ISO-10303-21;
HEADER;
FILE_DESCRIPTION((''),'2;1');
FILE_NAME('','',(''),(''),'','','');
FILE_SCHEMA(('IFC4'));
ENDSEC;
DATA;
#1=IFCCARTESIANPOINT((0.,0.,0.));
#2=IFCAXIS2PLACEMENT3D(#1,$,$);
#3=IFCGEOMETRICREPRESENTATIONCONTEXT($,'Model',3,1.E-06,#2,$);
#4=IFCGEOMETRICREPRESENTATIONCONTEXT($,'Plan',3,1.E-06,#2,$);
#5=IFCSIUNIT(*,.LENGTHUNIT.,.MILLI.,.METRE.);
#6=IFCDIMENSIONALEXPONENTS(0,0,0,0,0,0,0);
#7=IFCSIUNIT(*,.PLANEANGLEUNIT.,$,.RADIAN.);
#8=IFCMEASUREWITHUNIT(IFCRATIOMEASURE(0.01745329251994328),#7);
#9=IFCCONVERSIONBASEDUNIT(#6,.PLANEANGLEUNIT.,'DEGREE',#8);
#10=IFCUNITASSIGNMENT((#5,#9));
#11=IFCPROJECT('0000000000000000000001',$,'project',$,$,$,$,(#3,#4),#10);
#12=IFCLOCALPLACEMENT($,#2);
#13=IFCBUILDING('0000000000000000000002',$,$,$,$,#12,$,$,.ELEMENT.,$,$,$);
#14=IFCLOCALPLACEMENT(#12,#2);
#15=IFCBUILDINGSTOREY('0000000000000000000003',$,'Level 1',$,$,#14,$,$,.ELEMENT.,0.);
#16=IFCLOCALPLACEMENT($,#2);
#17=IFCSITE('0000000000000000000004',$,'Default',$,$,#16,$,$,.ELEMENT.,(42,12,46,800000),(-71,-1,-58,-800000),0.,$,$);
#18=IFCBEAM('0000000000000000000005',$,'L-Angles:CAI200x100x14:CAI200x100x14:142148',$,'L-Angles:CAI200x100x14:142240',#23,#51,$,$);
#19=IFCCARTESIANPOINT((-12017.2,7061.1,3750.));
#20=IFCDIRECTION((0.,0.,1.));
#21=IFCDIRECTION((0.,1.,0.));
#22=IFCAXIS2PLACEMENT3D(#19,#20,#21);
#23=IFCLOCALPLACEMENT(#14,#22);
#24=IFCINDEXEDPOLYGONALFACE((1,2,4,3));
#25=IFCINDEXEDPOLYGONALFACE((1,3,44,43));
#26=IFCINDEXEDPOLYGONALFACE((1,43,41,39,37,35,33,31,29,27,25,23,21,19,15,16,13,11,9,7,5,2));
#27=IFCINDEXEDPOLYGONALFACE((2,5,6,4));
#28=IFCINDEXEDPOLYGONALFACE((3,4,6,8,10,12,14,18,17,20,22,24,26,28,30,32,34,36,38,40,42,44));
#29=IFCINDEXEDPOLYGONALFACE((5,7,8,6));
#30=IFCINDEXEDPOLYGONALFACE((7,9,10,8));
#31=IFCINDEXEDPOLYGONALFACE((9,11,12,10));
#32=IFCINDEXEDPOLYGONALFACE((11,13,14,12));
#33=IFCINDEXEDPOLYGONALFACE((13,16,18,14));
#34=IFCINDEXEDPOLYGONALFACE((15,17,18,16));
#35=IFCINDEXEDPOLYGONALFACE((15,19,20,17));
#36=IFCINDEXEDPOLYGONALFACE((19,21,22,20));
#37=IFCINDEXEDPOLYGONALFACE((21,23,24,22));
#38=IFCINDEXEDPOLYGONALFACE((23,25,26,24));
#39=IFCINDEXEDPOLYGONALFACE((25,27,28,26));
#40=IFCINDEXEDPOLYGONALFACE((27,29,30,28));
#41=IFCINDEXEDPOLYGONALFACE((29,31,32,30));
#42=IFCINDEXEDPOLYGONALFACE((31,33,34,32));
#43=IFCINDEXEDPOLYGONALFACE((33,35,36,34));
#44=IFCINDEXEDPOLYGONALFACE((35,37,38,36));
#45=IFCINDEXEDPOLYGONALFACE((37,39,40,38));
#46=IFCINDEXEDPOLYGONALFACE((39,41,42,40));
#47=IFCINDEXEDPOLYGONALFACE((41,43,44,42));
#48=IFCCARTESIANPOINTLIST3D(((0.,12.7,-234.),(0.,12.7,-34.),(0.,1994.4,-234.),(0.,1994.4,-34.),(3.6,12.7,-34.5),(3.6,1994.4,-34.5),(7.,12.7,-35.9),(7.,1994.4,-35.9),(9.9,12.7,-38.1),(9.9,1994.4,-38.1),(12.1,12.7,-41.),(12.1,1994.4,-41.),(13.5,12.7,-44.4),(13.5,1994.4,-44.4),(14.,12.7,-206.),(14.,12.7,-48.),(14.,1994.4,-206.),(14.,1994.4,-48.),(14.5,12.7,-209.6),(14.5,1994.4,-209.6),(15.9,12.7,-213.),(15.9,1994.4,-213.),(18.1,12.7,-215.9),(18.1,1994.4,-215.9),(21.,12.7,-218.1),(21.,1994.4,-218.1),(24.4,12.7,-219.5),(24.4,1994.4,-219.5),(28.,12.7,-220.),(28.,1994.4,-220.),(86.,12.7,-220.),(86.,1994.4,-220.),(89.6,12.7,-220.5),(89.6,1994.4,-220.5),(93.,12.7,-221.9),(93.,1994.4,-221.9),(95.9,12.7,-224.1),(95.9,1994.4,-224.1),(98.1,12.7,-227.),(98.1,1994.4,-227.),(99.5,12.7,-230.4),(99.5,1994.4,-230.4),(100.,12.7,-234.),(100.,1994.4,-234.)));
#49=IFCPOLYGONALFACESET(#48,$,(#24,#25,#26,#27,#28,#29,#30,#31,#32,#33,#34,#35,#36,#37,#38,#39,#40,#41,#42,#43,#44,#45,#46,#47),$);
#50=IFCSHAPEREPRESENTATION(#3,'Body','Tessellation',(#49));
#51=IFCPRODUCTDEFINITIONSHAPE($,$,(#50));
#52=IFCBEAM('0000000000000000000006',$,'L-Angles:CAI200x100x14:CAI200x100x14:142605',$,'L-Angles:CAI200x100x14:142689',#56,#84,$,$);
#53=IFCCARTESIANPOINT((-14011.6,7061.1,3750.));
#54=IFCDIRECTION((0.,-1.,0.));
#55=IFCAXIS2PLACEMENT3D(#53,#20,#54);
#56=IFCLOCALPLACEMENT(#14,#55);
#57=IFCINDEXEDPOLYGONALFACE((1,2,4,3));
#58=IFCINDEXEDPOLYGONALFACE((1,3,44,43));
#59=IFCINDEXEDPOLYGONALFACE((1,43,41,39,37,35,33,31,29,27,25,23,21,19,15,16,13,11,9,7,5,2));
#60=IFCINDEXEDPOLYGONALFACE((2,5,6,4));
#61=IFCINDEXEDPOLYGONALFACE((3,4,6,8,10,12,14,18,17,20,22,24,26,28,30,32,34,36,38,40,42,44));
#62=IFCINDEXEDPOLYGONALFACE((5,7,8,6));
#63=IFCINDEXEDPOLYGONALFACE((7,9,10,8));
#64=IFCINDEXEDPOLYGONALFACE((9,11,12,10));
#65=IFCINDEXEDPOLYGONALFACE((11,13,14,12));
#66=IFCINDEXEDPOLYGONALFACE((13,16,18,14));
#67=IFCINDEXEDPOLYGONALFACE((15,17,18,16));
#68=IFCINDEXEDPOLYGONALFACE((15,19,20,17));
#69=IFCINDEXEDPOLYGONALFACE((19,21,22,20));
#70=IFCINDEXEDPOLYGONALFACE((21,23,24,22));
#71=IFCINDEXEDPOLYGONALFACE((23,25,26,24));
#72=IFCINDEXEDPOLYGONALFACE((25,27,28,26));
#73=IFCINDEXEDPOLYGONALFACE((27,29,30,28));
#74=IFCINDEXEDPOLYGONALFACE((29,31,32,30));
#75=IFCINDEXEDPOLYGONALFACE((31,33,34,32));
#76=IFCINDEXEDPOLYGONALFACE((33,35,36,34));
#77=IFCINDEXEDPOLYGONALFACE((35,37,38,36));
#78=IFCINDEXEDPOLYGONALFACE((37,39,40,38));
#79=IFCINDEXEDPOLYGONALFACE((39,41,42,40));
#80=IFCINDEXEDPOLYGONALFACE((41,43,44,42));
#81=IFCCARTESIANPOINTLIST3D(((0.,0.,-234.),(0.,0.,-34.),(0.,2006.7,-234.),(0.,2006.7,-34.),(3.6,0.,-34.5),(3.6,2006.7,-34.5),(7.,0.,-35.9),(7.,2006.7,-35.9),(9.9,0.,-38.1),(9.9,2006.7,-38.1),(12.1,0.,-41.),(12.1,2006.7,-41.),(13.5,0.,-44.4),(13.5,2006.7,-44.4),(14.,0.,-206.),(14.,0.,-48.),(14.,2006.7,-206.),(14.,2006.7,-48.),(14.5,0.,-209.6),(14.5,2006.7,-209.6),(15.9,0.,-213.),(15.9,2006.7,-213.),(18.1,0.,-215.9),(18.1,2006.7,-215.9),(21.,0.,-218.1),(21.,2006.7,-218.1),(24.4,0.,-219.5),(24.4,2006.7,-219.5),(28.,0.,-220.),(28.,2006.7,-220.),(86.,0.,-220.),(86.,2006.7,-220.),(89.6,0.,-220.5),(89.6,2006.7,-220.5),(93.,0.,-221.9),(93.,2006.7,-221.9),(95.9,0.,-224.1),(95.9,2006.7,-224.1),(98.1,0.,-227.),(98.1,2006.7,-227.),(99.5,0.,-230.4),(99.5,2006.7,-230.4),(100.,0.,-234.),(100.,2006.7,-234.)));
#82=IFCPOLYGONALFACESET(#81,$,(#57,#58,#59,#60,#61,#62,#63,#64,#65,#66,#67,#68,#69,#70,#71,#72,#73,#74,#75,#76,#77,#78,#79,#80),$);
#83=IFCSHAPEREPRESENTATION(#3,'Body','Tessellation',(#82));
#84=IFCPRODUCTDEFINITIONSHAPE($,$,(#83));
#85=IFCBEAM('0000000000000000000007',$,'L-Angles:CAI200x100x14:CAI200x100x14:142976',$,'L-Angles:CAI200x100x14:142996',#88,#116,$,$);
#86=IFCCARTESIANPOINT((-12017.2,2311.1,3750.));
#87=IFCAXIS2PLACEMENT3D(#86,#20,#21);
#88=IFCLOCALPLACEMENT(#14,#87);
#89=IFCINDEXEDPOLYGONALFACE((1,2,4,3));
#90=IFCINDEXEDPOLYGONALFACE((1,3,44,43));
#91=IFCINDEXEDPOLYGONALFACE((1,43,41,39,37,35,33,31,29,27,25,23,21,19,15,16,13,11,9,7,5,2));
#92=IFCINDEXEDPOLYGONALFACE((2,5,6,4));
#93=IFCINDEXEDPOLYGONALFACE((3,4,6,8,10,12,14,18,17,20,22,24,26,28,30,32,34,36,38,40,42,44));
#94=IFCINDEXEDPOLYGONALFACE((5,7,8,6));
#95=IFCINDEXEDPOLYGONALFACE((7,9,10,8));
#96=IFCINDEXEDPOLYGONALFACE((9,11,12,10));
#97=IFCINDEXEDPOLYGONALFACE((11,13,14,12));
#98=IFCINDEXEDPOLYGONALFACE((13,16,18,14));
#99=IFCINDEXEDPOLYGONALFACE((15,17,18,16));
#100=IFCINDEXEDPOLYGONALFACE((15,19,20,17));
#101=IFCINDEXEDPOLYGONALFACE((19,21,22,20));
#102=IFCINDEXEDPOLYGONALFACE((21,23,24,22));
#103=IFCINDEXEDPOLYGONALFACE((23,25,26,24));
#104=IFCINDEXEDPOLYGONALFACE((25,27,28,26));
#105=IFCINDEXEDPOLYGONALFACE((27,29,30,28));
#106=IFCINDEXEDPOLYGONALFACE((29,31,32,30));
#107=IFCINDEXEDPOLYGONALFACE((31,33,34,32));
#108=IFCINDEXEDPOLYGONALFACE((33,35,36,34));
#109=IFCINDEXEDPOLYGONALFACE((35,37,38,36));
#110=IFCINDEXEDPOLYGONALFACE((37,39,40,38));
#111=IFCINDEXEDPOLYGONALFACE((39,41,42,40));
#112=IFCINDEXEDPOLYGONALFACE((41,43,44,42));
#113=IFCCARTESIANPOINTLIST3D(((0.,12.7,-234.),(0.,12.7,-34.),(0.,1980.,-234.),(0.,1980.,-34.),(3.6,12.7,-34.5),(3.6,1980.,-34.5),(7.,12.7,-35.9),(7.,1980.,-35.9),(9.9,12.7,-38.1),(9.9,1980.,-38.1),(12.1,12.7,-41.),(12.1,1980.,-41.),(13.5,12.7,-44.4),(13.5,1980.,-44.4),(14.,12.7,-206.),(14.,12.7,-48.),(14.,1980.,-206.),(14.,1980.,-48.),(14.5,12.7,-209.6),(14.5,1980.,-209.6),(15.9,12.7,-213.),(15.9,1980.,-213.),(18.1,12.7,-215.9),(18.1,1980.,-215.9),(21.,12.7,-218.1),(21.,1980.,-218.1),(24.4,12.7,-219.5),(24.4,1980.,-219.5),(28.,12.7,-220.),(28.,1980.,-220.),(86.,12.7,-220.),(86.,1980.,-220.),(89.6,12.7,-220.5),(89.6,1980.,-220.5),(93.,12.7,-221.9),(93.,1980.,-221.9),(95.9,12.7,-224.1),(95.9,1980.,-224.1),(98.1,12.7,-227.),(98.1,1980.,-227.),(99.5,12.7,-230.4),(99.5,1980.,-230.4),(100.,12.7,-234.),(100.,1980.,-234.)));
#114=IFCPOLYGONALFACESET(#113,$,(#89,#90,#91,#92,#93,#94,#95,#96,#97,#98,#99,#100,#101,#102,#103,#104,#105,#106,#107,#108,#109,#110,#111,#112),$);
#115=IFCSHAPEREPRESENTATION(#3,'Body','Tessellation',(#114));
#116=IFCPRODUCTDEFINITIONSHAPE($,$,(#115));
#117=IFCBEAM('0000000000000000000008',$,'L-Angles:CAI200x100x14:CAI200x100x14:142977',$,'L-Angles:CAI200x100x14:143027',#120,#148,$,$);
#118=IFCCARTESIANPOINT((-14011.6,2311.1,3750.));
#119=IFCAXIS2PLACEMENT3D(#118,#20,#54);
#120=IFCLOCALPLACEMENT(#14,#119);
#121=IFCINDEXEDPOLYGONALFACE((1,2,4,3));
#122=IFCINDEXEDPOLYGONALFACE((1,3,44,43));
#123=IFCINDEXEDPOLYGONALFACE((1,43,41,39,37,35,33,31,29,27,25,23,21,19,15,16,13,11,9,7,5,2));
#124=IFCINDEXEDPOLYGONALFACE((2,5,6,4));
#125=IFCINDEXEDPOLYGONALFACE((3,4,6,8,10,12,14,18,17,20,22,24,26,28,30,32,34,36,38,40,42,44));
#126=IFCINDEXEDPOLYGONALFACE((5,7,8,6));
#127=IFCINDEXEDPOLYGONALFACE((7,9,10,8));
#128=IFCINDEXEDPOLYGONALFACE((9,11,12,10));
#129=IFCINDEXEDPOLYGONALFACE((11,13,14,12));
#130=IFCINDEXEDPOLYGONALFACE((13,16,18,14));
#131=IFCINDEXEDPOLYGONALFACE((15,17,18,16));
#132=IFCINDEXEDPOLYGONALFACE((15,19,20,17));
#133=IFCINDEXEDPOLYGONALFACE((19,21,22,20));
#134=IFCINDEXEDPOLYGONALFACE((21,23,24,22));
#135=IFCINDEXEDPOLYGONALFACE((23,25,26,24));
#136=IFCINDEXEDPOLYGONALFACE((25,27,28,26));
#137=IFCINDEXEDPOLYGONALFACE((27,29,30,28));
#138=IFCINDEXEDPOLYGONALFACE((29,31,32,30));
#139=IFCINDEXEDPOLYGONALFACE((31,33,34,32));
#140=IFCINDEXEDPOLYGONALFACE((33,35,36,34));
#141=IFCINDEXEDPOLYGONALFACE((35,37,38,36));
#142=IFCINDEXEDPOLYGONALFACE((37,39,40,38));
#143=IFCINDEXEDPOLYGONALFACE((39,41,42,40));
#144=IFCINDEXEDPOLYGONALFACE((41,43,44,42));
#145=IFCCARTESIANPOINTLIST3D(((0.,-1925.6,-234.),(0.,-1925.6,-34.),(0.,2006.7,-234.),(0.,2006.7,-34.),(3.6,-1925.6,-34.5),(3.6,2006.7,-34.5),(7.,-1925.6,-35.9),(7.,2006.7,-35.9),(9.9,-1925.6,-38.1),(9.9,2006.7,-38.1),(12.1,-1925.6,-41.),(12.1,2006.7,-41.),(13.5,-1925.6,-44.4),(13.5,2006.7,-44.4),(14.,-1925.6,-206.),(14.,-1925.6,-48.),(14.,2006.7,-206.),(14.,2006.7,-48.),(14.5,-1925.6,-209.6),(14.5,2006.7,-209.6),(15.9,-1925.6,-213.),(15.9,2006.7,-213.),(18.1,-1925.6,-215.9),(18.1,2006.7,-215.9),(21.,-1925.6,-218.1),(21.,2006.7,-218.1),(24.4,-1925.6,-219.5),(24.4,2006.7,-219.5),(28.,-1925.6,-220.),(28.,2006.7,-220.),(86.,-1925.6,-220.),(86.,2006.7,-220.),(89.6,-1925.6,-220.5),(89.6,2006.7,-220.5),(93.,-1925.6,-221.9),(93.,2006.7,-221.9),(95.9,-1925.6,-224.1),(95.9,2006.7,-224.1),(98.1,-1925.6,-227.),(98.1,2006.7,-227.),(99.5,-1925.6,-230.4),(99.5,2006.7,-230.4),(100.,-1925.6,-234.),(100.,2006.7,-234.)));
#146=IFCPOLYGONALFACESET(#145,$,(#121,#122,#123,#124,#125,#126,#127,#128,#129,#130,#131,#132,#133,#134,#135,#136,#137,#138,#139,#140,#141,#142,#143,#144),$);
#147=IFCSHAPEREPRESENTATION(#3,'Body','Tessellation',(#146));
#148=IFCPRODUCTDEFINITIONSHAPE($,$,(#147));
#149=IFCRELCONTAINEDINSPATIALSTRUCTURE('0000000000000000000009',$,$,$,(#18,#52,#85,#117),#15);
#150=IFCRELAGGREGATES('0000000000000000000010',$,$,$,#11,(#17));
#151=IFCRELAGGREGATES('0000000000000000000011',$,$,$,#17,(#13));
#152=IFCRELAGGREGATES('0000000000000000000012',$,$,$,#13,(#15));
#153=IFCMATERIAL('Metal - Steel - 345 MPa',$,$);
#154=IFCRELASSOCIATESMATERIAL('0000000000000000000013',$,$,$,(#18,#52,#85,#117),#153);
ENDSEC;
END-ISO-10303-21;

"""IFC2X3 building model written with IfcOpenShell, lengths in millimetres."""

from ifc_helpers import new_model, entity, si_unit, converted_unit, frame, frame_2d, origin, place, context, project, spatial, polyline, circle_curve, parameter, trimmed, segment, composite_curve, outline, extrude, material, element, save


model = new_model("IFC2X3")

# Units and contexts
model_context = context("Model", 3, precision=1e-06, world=origin())
plan_context = context("Plan", 3, precision=1e-06, world=origin())
ifc_project = project(units=[si_unit("LENGTHUNIT", "METRE", prefix="MILLI"), converted_unit("PLANEANGLEUNIT", "DEGREE", entity("IfcRatioMeasure", 0.01745329251994328), si_unit("PLANEANGLEUNIT", "RADIAN"), dimensions=[0, 0, 0, 0, 0, 0, 0])], contexts=[model_context, plan_context])

# Site, building, storey
site_placement = place(None, origin())
site = spatial("IfcSite", under=ifc_project, at=site_placement, Name="Default", CompositionType="ELEMENT", RefLatitude=(42, 12, 46, 800000), RefLongitude=(-71, -1, -58, -800000), RefElevation=0.0)
building_placement = place(None, origin())
building = spatial("IfcBuilding", under=site, at=building_placement, CompositionType="ELEMENT")
storey_placement = place(building_placement, origin())
storey = spatial("IfcBuildingStorey", under=building, at=storey_placement, Name="Level 1", CompositionType="ELEMENT", Elevation=0.0)

# Shared definitions
ifc_material_1 = material(Name="Metal - Steel - 345 MPa")

# Beams
beam_1_placement = place(storey_placement, frame((-12017.2, 7061.1, 3750.0), z_axis=(0.0, 0.0, 1.0), x_axis=(0.0, 1.0, 0.0)))
element("IfcBeam", 1, at=beam_1_placement, inside=storey, material=ifc_material_1, Name="L-Angles:CAI200x100x14:CAI200x100x14:142148", ObjectType="L-Angles:CAI200x100x14:142240", context=model_context, shape_type="SweptSolid", body=[
    extrude(outline(composite_curve([segment(polyline([(-34.6, -63.1), (65.4, -63.1)]), True, "CONTINUOUS"), segment(trimmed(circle_curve(frame_2d((51.4, -63.1), x_axis=(1.0, 0.0)), 14.0), [parameter(0.0)], [parameter(90.0)], True, "PARAMETER"), True, "CONTINUOUS"), segment(polyline([(51.4, -49.1), (-6.6, -49.1)]), True, "CONTINUOUS"), segment(trimmed(circle_curve(frame_2d((-6.6, -35.1), x_axis=(1.0, 0.0)), 14.0), [parameter(180.0)], [parameter(270.0)], True, "PARAMETER"), False, "CONTINUOUS"), segment(polyline([(-20.6, -35.1), (-20.6, 122.9)]), True, "CONTINUOUS"), segment(trimmed(circle_curve(frame_2d((-34.6, 122.9), x_axis=(1.0, 0.0)), 14.0), [parameter(0.0)], [parameter(90.0)], True, "PARAMETER"), True, "CONTINUOUS"), segment(polyline([(-34.6, 136.9), (-34.6, -63.1)]), True, "CONTINUOUS")], self_intersect=False)), frame((34.6, 1994.4, -170.9), z_axis=(0.0, -1.0, 0.0), x_axis=(1.0, 0.0, 0.0)), (0.0, 0.0, 1.0), 1981.7),
])
beam_2_placement = place(storey_placement, frame((-14011.6, 7061.1, 3750.0), z_axis=(0.0, 0.0, 1.0), x_axis=(0.0, -1.0, 0.0)))
element("IfcBeam", 2, at=beam_2_placement, inside=storey, material=ifc_material_1, Name="L-Angles:CAI200x100x14:CAI200x100x14:142605", ObjectType="L-Angles:CAI200x100x14:142689", context=model_context, shape_type="SweptSolid", body=[
    extrude(outline(composite_curve([segment(polyline([(-63.1, -34.6), (136.9, -34.6)]), True, "CONTINUOUS"), segment(trimmed(circle_curve(frame_2d((122.9, -34.6), x_axis=(0.0, 1.0)), 14.0), [parameter(270.0)], [parameter(0.0)], True, "PARAMETER"), True, "CONTINUOUS"), segment(polyline([(122.9, -20.6), (-35.1, -20.6)]), True, "CONTINUOUS"), segment(trimmed(circle_curve(frame_2d((-35.1, -6.6), x_axis=(0.0, 1.0)), 14.0), [parameter(90.0)], [parameter(180.0)], True, "PARAMETER"), False, "CONTINUOUS"), segment(polyline([(-49.1, -6.6), (-49.1, 51.4)]), True, "CONTINUOUS"), segment(trimmed(circle_curve(frame_2d((-63.1, 51.4), x_axis=(0.0, 1.0)), 14.0), [parameter(270.0)], [parameter(360.0)], True, "PARAMETER"), True, "CONTINUOUS"), segment(polyline([(-63.1, 65.4), (-63.1, -34.6)]), True, "CONTINUOUS")], self_intersect=False)), frame((34.6, 0.0, -170.9), z_axis=(0.0, 1.0, 0.0), x_axis=(0.0, 0.0, 1.0)), (0.0, 0.0, 1.0), 2006.7),
])
beam_3_placement = place(storey_placement, frame((-12017.2, 2311.1, 3750.0), z_axis=(0.0, 0.0, 1.0), x_axis=(0.0, 1.0, 0.0)))
element("IfcBeam", 3, at=beam_3_placement, inside=storey, material=ifc_material_1, Name="L-Angles:CAI200x100x14:CAI200x100x14:142976", ObjectType="L-Angles:CAI200x100x14:142996", context=model_context, shape_type="SweptSolid", body=[
    extrude(outline(composite_curve([segment(polyline([(-34.6, -63.1), (65.4, -63.1)]), True, "CONTINUOUS"), segment(trimmed(circle_curve(frame_2d((51.4, -63.1), x_axis=(0.0, 1.0)), 14.0), [parameter(270.0)], [parameter(360.0)], True, "PARAMETER"), True, "CONTINUOUS"), segment(polyline([(51.4, -49.1), (-6.6, -49.1)]), True, "CONTINUOUS"), segment(trimmed(circle_curve(frame_2d((-6.6, -35.1), x_axis=(-1.0, 0.0)), 14.0), [parameter(0.0)], [parameter(90.0)], True, "PARAMETER"), False, "CONTINUOUS"), segment(polyline([(-20.6, -35.1), (-20.6, 122.9)]), True, "CONTINUOUS"), segment(trimmed(circle_curve(frame_2d((-34.6, 122.9), x_axis=(0.0, 1.0)), 14.0), [parameter(270.0)], [parameter(0.0)], True, "PARAMETER"), True, "CONTINUOUS"), segment(polyline([(-34.6, 136.9), (-34.6, -63.1)]), True, "CONTINUOUS")], self_intersect=False)), frame((34.6, 1980.0, -170.9), z_axis=(0.0, -1.0, 0.0), x_axis=(1.0, 0.0, 0.0)), (0.0, 0.0, 1.0), 1967.3),
])
beam_4_placement = place(storey_placement, frame((-14011.6, 2311.1, 3750.0), z_axis=(0.0, 0.0, 1.0), x_axis=(0.0, -1.0, 0.0)))
element("IfcBeam", 4, at=beam_4_placement, inside=storey, material=ifc_material_1, Name="L-Angles:CAI200x100x14:CAI200x100x14:142977", ObjectType="L-Angles:CAI200x100x14:143027", context=model_context, shape_type="SweptSolid", body=[
    extrude(outline(composite_curve([segment(polyline([(-63.1, -34.6), (136.9, -34.6)]), True, "CONTINUOUS"), segment(trimmed(circle_curve(frame_2d((122.9, -34.6), x_axis=(1.0, 0.0)), 14.0), [parameter(360.0)], [parameter(90.0)], True, "PARAMETER"), True, "CONTINUOUS"), segment(polyline([(122.9, -20.6), (-35.1, -20.6)]), True, "CONTINUOUS"), segment(trimmed(circle_curve(frame_2d((-35.1, -6.6), x_axis=(0.0, -1.0)), 14.0), [parameter(270.0)], [parameter(360.0)], True, "PARAMETER"), False, "CONTINUOUS"), segment(polyline([(-49.1, -6.6), (-49.1, 51.4)]), True, "CONTINUOUS"), segment(trimmed(circle_curve(frame_2d((-63.1, 51.4), x_axis=(1.0, 0.0)), 14.0), [parameter(0.0)], [parameter(90.0)], True, "PARAMETER"), True, "CONTINUOUS"), segment(polyline([(-63.1, 65.4), (-63.1, -34.6)]), True, "CONTINUOUS")], self_intersect=False)), frame((34.6, -1925.6, -170.9), z_axis=(0.0, 1.0, 0.0), x_axis=(0.0, 0.0, 1.0)), (0.0, 0.0, 1.0), 3932.3),
])

save(model, "model.ifc")
